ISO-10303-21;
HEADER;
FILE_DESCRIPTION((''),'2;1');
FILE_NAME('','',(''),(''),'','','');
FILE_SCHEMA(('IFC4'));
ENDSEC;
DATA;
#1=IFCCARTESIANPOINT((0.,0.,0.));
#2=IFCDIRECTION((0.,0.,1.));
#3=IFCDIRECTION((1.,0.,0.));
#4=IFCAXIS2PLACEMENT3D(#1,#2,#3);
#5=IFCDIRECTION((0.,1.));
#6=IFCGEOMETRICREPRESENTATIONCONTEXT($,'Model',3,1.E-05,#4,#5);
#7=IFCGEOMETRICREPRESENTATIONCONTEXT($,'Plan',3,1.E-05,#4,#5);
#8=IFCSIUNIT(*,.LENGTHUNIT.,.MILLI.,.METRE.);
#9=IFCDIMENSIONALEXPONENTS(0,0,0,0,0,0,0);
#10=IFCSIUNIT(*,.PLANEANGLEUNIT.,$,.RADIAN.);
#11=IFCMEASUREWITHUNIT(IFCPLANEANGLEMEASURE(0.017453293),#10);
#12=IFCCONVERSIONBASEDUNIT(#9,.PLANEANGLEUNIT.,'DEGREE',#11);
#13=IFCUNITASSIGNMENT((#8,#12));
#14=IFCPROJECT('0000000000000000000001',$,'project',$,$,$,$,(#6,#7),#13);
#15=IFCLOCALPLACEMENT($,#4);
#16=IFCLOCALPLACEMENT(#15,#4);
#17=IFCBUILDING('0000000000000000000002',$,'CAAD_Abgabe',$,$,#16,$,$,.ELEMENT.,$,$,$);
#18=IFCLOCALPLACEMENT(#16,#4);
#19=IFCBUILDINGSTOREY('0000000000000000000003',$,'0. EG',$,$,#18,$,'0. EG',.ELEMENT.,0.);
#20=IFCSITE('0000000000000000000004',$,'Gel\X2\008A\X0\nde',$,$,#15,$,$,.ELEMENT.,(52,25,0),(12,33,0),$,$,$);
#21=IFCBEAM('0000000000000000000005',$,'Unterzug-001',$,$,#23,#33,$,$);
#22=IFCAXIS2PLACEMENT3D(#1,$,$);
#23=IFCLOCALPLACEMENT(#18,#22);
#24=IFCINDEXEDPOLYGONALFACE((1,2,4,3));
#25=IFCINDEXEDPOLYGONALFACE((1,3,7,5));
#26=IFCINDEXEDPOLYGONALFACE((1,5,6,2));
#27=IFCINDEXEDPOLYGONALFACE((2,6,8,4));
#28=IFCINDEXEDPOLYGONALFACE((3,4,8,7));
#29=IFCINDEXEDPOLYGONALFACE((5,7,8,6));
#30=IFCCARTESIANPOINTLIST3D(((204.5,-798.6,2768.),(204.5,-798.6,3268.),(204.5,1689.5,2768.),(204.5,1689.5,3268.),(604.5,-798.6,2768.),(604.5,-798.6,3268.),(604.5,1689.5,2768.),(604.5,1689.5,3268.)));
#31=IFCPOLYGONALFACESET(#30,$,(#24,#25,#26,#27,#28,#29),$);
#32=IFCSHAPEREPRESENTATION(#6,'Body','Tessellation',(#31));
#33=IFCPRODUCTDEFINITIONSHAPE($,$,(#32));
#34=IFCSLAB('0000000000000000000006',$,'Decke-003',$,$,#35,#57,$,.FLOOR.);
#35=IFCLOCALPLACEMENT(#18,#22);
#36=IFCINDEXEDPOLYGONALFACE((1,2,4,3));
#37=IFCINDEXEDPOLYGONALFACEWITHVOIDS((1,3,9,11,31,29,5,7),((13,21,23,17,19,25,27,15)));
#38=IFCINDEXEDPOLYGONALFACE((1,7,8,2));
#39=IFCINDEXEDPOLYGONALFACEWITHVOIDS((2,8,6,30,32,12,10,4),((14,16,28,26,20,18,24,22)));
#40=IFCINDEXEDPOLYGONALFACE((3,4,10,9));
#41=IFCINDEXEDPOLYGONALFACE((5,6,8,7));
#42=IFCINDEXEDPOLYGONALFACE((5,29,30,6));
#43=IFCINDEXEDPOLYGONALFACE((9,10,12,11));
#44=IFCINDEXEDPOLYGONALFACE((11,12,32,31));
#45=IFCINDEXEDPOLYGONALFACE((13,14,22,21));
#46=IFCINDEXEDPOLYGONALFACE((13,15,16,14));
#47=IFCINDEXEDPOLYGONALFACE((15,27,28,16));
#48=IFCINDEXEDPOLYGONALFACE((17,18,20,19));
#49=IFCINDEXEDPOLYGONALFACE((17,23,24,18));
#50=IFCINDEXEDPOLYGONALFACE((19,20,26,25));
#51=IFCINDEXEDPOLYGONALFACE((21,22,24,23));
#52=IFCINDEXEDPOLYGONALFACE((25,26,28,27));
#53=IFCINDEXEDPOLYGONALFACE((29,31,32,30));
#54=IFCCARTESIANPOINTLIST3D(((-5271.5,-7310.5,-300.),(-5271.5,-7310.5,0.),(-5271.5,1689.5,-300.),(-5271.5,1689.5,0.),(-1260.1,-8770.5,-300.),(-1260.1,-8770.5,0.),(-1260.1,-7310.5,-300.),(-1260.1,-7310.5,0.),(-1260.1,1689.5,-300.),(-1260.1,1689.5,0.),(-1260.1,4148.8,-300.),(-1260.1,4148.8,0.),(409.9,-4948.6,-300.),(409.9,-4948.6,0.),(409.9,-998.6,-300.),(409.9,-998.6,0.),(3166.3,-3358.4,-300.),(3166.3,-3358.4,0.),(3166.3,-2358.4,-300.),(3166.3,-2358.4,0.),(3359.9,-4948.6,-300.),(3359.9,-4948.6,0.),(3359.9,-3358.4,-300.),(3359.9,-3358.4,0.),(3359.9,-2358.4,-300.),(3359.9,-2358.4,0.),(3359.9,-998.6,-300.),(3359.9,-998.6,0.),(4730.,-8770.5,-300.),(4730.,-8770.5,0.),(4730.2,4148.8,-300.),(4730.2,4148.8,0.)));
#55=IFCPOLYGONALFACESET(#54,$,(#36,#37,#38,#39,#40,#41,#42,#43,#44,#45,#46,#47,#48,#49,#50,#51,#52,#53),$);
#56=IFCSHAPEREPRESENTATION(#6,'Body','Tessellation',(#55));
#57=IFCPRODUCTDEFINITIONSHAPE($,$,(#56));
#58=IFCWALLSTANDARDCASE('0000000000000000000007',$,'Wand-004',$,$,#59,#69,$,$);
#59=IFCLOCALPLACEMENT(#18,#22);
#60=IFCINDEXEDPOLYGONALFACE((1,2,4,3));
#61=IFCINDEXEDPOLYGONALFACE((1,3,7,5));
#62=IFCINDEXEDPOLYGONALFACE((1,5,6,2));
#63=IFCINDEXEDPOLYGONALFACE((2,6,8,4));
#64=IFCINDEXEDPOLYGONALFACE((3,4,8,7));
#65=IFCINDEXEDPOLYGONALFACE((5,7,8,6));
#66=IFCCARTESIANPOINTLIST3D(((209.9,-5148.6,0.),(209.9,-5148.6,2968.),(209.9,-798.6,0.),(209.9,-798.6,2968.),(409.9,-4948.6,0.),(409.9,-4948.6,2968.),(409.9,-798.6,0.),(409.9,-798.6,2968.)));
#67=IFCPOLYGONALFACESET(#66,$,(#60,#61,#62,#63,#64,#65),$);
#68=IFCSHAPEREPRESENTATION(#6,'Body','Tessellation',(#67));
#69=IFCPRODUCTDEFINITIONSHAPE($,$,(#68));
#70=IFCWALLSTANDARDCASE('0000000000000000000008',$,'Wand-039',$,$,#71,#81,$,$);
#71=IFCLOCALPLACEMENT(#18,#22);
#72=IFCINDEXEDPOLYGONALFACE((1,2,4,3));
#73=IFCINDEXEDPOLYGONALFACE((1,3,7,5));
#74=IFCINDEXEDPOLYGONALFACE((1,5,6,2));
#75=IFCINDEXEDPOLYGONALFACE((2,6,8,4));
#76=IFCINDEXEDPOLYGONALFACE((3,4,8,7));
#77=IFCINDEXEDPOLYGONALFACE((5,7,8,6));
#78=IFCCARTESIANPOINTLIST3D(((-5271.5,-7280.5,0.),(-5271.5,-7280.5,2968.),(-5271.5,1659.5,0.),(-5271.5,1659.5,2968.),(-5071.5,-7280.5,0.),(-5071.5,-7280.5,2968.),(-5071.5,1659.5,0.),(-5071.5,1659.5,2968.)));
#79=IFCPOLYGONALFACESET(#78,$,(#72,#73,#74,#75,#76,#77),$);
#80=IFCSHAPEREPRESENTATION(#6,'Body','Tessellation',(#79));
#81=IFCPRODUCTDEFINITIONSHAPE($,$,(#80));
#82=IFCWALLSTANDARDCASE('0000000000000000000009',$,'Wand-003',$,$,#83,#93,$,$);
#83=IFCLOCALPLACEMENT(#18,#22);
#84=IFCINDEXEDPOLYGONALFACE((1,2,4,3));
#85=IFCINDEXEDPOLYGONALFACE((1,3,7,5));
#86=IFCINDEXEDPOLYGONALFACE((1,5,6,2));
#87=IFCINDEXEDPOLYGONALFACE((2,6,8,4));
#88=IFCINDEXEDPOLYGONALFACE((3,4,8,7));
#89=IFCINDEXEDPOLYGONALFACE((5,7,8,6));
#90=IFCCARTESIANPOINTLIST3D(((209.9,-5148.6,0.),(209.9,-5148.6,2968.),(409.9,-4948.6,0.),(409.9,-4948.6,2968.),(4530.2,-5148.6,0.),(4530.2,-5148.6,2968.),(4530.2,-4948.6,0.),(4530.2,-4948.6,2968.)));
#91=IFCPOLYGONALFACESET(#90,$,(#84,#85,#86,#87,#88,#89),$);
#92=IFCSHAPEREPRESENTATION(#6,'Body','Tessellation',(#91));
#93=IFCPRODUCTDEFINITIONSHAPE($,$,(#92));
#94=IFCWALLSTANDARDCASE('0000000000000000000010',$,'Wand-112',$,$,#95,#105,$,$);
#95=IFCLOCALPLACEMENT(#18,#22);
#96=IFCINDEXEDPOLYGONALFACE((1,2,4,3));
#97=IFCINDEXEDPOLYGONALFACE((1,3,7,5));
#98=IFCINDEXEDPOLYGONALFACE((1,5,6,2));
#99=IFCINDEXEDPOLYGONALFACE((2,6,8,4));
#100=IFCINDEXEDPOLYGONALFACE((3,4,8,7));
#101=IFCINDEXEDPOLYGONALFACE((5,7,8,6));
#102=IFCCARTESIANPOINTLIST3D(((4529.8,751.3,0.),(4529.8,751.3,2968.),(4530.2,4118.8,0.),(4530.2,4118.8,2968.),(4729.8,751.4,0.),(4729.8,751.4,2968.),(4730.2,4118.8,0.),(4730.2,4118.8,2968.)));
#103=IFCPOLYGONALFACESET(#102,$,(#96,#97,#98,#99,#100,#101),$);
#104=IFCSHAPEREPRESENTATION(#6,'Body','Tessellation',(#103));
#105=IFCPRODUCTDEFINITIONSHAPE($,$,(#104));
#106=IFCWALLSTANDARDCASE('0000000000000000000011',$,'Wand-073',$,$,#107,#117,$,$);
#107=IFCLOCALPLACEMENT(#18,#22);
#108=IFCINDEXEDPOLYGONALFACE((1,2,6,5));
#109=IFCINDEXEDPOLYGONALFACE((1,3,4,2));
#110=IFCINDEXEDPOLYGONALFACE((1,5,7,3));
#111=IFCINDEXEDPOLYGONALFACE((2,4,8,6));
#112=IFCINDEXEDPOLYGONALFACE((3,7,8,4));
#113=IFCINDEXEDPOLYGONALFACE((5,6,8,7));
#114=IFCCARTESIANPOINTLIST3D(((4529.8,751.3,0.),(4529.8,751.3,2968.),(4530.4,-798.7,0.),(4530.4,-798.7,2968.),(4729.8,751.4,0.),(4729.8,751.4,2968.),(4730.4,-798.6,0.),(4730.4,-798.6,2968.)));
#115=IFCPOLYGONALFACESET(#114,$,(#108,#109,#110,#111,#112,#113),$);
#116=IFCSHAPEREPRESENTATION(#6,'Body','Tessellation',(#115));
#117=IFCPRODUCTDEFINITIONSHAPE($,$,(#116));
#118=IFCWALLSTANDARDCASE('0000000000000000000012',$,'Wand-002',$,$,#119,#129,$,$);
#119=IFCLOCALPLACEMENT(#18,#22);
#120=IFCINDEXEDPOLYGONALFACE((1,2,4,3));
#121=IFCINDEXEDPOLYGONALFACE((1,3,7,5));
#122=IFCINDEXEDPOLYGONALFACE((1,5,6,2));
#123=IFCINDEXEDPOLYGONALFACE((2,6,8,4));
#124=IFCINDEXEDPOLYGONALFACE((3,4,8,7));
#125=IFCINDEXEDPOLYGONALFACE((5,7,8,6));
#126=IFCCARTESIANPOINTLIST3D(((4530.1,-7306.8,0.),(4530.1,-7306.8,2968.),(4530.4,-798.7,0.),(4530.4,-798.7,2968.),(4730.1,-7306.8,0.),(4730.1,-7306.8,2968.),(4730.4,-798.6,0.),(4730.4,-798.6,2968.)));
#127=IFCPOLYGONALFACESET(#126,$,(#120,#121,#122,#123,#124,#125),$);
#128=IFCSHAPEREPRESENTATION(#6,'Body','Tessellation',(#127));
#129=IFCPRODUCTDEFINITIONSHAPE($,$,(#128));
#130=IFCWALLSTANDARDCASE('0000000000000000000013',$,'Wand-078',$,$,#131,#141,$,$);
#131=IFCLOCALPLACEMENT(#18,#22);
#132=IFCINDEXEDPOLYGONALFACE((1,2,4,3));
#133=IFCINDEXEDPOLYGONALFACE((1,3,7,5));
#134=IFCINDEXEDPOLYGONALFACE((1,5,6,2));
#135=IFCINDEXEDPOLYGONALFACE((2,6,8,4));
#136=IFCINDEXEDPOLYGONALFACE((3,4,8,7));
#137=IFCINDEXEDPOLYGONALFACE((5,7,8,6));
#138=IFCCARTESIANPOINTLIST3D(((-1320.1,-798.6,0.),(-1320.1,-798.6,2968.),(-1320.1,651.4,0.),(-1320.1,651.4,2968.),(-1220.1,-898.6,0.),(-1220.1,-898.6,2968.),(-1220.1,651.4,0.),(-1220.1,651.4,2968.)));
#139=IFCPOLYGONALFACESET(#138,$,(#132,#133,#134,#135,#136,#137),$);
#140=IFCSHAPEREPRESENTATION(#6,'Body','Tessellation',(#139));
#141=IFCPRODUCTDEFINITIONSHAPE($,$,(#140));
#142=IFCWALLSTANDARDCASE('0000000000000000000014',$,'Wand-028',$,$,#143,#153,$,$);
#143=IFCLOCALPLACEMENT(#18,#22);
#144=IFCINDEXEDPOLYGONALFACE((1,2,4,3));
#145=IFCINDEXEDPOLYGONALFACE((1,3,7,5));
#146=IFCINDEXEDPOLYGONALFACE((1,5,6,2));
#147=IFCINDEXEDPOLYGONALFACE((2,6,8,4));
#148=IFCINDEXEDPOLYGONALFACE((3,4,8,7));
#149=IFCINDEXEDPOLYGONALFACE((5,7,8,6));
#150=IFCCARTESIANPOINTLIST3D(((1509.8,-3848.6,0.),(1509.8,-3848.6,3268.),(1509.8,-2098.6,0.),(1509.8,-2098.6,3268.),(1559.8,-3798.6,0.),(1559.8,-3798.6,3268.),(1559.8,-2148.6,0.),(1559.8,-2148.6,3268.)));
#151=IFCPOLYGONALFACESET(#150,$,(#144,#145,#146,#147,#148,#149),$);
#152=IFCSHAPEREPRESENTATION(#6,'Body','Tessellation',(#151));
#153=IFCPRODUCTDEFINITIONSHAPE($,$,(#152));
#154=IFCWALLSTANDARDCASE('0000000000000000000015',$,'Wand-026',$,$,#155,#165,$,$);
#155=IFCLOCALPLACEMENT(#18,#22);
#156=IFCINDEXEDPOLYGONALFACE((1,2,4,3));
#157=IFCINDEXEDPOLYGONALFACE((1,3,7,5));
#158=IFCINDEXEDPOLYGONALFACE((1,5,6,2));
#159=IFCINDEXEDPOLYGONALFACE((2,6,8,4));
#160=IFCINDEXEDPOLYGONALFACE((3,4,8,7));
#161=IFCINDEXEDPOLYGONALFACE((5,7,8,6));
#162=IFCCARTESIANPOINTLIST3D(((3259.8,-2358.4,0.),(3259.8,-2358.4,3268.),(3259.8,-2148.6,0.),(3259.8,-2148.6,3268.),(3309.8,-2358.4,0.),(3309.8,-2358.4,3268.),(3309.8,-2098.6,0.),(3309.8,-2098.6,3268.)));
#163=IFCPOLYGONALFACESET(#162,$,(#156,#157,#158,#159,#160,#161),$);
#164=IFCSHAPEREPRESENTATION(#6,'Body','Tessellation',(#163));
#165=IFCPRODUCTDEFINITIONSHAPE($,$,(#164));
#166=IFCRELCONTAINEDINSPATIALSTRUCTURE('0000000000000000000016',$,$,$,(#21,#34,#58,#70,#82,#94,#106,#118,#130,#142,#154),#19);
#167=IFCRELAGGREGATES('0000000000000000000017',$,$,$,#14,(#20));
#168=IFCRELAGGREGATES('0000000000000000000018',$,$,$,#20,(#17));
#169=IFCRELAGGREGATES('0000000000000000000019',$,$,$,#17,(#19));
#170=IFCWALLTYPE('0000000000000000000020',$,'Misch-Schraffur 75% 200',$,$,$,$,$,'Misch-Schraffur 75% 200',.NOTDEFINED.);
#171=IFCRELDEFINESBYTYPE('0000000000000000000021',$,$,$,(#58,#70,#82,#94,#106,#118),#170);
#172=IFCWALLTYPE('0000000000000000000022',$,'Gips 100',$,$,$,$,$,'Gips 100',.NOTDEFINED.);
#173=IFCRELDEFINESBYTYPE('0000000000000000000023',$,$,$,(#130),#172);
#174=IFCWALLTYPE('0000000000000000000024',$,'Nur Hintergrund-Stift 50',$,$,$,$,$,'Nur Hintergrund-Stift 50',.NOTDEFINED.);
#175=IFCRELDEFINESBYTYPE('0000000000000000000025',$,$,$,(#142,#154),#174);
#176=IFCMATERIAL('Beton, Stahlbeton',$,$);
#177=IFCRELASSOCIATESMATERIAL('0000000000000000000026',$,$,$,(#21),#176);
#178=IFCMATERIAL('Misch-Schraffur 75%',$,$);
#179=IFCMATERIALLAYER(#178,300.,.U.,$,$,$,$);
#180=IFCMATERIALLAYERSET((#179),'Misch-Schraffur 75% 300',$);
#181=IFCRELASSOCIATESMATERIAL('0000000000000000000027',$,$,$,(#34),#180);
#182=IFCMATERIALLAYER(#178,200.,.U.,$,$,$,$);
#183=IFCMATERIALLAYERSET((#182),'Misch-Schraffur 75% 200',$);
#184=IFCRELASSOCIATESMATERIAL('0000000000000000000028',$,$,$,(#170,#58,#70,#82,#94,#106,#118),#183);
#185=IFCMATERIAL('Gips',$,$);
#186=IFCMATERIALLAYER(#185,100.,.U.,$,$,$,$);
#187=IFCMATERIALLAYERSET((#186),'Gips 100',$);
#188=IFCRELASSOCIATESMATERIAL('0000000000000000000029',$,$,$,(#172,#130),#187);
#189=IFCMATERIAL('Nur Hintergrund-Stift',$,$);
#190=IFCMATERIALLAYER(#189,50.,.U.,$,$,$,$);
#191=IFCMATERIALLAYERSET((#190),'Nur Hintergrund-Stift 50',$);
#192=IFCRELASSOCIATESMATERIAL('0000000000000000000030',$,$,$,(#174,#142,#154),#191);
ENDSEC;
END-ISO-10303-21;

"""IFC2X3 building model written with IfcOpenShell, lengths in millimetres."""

from ifc_helpers import new_model, entity, si_unit, converted_unit, direction, frame, origin_with_axes, place, context, project, spatial, polyline, outline, extrude, material, layer, layer_set, layer_usage, type_object, element, save


model = new_model("IFC2X3")

# Units and contexts
model_context = context("Model", 3, precision=1e-05, world=origin_with_axes(), true_north=direction((0.0, 1.0)))
plan_context = context("Plan", 3, precision=1e-05, world=origin_with_axes(), true_north=direction((0.0, 1.0)))
ifc_project = project(units=[si_unit("LENGTHUNIT", "METRE", prefix="MILLI"), converted_unit("PLANEANGLEUNIT", "DEGREE", entity("IfcPlaneAngleMeasure", 0.017453293), si_unit("PLANEANGLEUNIT", "RADIAN"), dimensions=[0, 0, 0, 0, 0, 0, 0])], contexts=[model_context, plan_context])

# Site, building, storey
site_placement = place(None, origin_with_axes())
site = spatial("IfcSite", under=ifc_project, at=site_placement, Name="Gel\u008ande", CompositionType="ELEMENT", RefLatitude=(52, 25, 0), RefLongitude=(12, 33, 0))
building_placement = place(site_placement, origin_with_axes())
building = spatial("IfcBuilding", under=site, at=building_placement, Name="CAAD_Abgabe", CompositionType="ELEMENT")
storey_placement = place(building_placement, origin_with_axes())
storey = spatial("IfcBuildingStorey", under=building, at=storey_placement, Name="0. EG", LongName="0. EG", CompositionType="ELEMENT", Elevation=0.0)

# Beam
ifc_material_1 = material(Name="Beton, Stahlbeton")
beam_placement = place(storey_placement, frame((404.5, 1689.5, 3268.0), z_axis=(0.0, 0.0, 1.0), x_axis=(-1.0, 0.0, 0.0)))
element("IfcBeam", 1, at=beam_placement, inside=storey, material=ifc_material_1, Name="Unterzug-001", context=model_context, shape_type="SweptSolid", body=[
    extrude(outline(polyline([(-200.0, -500.0), (200.0, -500.0), (200.0, 0.0), (-200.0, 0.0), (-200.0, -500.0)])), frame((0.0, 2488.1, 0.0), z_axis=(0.0, -1.0, 0.0), x_axis=(1.0, 0.0, 0.0)), (0.0, 0.0, 1.0), 2488.1),
])

# Slab, opening
ifc_material_2 = material(Name="Misch-Schraffur 75%")
ifc_layer_1 = layer(ifc_material_2, 300.0, ventilated="UNKNOWN")
ifc_layer_set_1 = layer_set([ifc_layer_1], Name="Misch-Schraffur 75% 300")
ifc_layer_usage_1 = layer_usage(ifc_layer_set_1, "AXIS3", "NEGATIVE", 300.0)
slab_placement = place(storey_placement, frame((-5271.5, -7310.5, -300.0), z_axis=(0.0, 0.0, 1.0), x_axis=(1.0, 0.0, 0.0)))
slab = element("IfcSlab", 2, at=slab_placement, inside=storey, material=ifc_layer_usage_1, Name="Decke-003", PredefinedType="FLOOR", context=model_context, shape_type="SweptSolid", body=[
    extrude(outline(polyline([(0.0, 0.0), (4011.4, 0.0), (4011.4, -1460.0), (10001.5, -1460.0), (10001.7, 11459.3), (4011.4, 11459.3), (4011.4, 9000.0), (0.0, 9000.0), (0.0, 0.0)])), origin_with_axes(), (0.0, 0.0, 1.0), 300.0),
])
opening_1_placement = place(slab_placement, origin_with_axes())
element("IfcOpeningElement", 3, at=opening_1_placement, cuts=slab, context=model_context, shape_type="SweptSolid", body=[
    extrude(outline(polyline([(5681.4, 2361.9), (5681.4, 6311.9), (8631.4, 6311.9), (8631.4, 4952.1), (8437.8, 4952.1), (8437.8, 3952.1), (8631.4, 3952.1), (8631.4, 2361.9), (5681.4, 2361.9)])), origin_with_axes(), (0.0, 0.0, 1.0), 300.0),
])

# Walls
ifc_layer_2 = layer(ifc_material_2, 200.0, ventilated="UNKNOWN")
ifc_layer_set_2 = layer_set([ifc_layer_2], Name="Misch-Schraffur 75% 200")
ifc_layer_usage_2 = layer_usage(ifc_layer_set_2, "AXIS2", "NEGATIVE", 0.0)
wall_type_1 = type_object("IfcWallType", Name="Misch-Schraffur 75% 200", ElementType="Misch-Schraffur 75% 200", PredefinedType="NOTDEFINED", material=ifc_layer_set_2)
wall_1_placement = place(storey_placement, frame((209.9, -5148.6, 0.0), z_axis=(0.0, 0.0, 1.0), x_axis=(0.0, 1.0, 0.0)))
element("IfcWallStandardCase", 4, at=wall_1_placement, inside=storey, type_object=wall_type_1, material=ifc_layer_usage_2, Name="Wand-004", context=model_context, shape_type="SweptSolid", body=[
    extrude(outline(polyline([(200.0, -200.0), (4350.0, -200.0), (4350.0, 0.0), (0.0, 0.0), (200.0, -200.0)])), origin_with_axes(), (0.0, 0.0, 1.0), 2968.0),
])
ifc_layer_usage_3 = layer_usage(ifc_layer_set_2, "AXIS2", "POSITIVE", 0.0)
wall_2_placement = place(storey_placement, frame((-5271.5, 1659.5, 0.0), z_axis=(0.0, 0.0, 1.0), x_axis=(0.0, -1.0, 0.0)))
element("IfcWallStandardCase", 5, at=wall_2_placement, inside=storey, type_object=wall_type_1, material=ifc_layer_usage_3, Name="Wand-039", context=model_context, shape_type="SweptSolid", body=[
    extrude(outline(polyline([(0.0, 0.0), (8940.0, 0.0), (8940.0, 200.0), (0.0, 200.0), (0.0, 0.0)])), origin_with_axes(), (0.0, 0.0, 1.0), 2968.0),
])
ifc_layer_usage_4 = layer_usage(ifc_layer_set_2, "AXIS2", "NEGATIVE", 0.0)
wall_3_placement = place(storey_placement, frame((4730.2, -5148.6, 0.0), z_axis=(0.0, 0.0, 1.0), x_axis=(-1.0, -0.000004, 0.0)))
element("IfcWallStandardCase", 6, at=wall_3_placement, inside=storey, type_object=wall_type_1, material=ifc_layer_usage_4, Name="Wand-003", context=model_context, shape_type="SweptSolid", body=[
    extrude(outline(polyline([(200.0, -200.0), (4320.3, -200.0), (4520.3, 0.0), (200.0, 0.0), (200.0, -200.0)])), origin_with_axes(), (0.0, 0.0, 1.0), 2968.0),
])

# Walls
ifc_layer_usage_5 = layer_usage(ifc_layer_set_2, "AXIS2", "NEGATIVE", 0.0)
wall_4_placement = place(storey_placement, frame((4730.2, 4118.8, 0.0), z_axis=(0.0, 0.0, 1.0), x_axis=(-0.000115, -1.0, 0.0)))
element("IfcWallStandardCase", 7, at=wall_4_placement, inside=storey, type_object=wall_type_1, material=ifc_layer_usage_5, Name="Wand-112", context=model_context, shape_type="SweptSolid", body=[
    extrude(outline(polyline([(0.0, -200.0), (3367.5, -200.0), (3367.5, 0.0), (0.0, 0.0), (0.0, -200.0)])), origin_with_axes(), (0.0, 0.0, 1.0), 2968.0),
])
ifc_layer_usage_6 = layer_usage(ifc_layer_set_2, "AXIS2", "NEGATIVE", 0.0)
wall_5_placement = place(storey_placement, frame((4729.8, 751.4, 0.0), z_axis=(0.0, 0.0, 1.0), x_axis=(0.000391, -1.0, 0.0)))
element("IfcWallStandardCase", 8, at=wall_5_placement, inside=storey, type_object=wall_type_1, material=ifc_layer_usage_6, Name="Wand-073", context=model_context, shape_type="SweptSolid", body=[
    extrude(outline(polyline([(-0.1, -200.0), (1550.0, -200.0), (1550.0, 0.0), (0.0, 0.0), (-0.1, -200.0)])), origin_with_axes(), (0.0, 0.0, 1.0), 2968.0),
])
ifc_layer_usage_7 = layer_usage(ifc_layer_set_2, "AXIS2", "NEGATIVE", 0.0)
wall_6_placement = place(storey_placement, frame((4730.4, -798.6, 0.0), z_axis=(0.0, 0.0, 1.0), x_axis=(-0.000049, -1.0, 0.0)))
element("IfcWallStandardCase", 9, at=wall_6_placement, inside=storey, type_object=wall_type_1, material=ifc_layer_usage_7, Name="Wand-002", context=model_context, shape_type="SweptSolid", body=[
    extrude(outline(polyline([(0.0, -200.0), (6508.1, -200.0), (6508.1, 0.0), (0.0, 0.0), (0.0, -200.0)])), origin_with_axes(), (0.0, 0.0, 1.0), 2968.0),
])
ifc_material_3 = material(Name="Gips")
ifc_layer_3 = layer(ifc_material_3, 100.0, ventilated="UNKNOWN")
ifc_layer_set_3 = layer_set([ifc_layer_3], Name="Gips 100")
wall_type_2 = type_object("IfcWallType", Name="Gips 100", ElementType="Gips 100", PredefinedType="NOTDEFINED", material=ifc_layer_set_3)
ifc_layer_usage_8 = layer_usage(ifc_layer_set_3, "AXIS2", "POSITIVE", 0.0)
wall_7_placement = place(storey_placement, frame((-1220.1, -798.6, 0.0), z_axis=(0.0, 0.0, 1.0), x_axis=(0.0, 1.0, 0.0)))
element("IfcWallStandardCase", 10, at=wall_7_placement, inside=storey, type_object=wall_type_2, material=ifc_layer_usage_8, Name="Wand-078", context=model_context, shape_type="SweptSolid", body=[
    extrude(outline(polyline([(-100.0, 0.0), (1450.0, 0.0), (1450.0, 100.0), (0.0, 100.0), (-100.0, 0.0)])), origin_with_axes(), (0.0, 0.0, 1.0), 2968.0),
])
ifc_material_4 = material(Name="Nur Hintergrund-Stift")
ifc_layer_4 = layer(ifc_material_4, 50.0, ventilated="UNKNOWN")
ifc_layer_set_4 = layer_set([ifc_layer_4], Name="Nur Hintergrund-Stift 50")
ifc_layer_usage_9 = layer_usage(ifc_layer_set_4, "AXIS2", "NEGATIVE", 0.0)
wall_type_3 = type_object("IfcWallType", Name="Nur Hintergrund-Stift 50", ElementType="Nur Hintergrund-Stift 50", PredefinedType="NOTDEFINED", material=ifc_layer_set_4)
wall_8_placement = place(storey_placement, frame((1559.8, -2148.6, 0.0), z_axis=(0.0, 0.0, 1.0), x_axis=(0.0, -1.0, 0.0)))
element("IfcWallStandardCase", 11, at=wall_8_placement, inside=storey, type_object=wall_type_3, material=ifc_layer_usage_9, Name="Wand-028", context=model_context, shape_type="SweptSolid", body=[
    extrude(outline(polyline([(-50.0, -50.0), (1700.0, -50.0), (1650.0, 0.0), (0.0, 0.0), (-50.0, -50.0)])), origin_with_axes(), (0.0, 0.0, 1.0), 3268.0),
])
ifc_layer_usage_10 = layer_usage(ifc_layer_set_4, "AXIS2", "POSITIVE", 0.0)
wall_9_placement = place(storey_placement, frame((3309.8, -2358.4, 0.0), z_axis=(0.0, 0.0, 1.0), x_axis=(0.0, 1.0, 0.0)))
element("IfcWallStandardCase", 12, at=wall_9_placement, inside=storey, type_object=wall_type_3, material=ifc_layer_usage_10, Name="Wand-026", context=model_context, shape_type="SweptSolid", body=[
    extrude(outline(polyline([(0.0, 0.0), (259.8, 0.0), (209.8, 50.0), (0.0, 50.0), (0.0, 0.0)])), origin_with_axes(), (0.0, 0.0, 1.0), 3268.0),
])

save(model, "model.ifc")
